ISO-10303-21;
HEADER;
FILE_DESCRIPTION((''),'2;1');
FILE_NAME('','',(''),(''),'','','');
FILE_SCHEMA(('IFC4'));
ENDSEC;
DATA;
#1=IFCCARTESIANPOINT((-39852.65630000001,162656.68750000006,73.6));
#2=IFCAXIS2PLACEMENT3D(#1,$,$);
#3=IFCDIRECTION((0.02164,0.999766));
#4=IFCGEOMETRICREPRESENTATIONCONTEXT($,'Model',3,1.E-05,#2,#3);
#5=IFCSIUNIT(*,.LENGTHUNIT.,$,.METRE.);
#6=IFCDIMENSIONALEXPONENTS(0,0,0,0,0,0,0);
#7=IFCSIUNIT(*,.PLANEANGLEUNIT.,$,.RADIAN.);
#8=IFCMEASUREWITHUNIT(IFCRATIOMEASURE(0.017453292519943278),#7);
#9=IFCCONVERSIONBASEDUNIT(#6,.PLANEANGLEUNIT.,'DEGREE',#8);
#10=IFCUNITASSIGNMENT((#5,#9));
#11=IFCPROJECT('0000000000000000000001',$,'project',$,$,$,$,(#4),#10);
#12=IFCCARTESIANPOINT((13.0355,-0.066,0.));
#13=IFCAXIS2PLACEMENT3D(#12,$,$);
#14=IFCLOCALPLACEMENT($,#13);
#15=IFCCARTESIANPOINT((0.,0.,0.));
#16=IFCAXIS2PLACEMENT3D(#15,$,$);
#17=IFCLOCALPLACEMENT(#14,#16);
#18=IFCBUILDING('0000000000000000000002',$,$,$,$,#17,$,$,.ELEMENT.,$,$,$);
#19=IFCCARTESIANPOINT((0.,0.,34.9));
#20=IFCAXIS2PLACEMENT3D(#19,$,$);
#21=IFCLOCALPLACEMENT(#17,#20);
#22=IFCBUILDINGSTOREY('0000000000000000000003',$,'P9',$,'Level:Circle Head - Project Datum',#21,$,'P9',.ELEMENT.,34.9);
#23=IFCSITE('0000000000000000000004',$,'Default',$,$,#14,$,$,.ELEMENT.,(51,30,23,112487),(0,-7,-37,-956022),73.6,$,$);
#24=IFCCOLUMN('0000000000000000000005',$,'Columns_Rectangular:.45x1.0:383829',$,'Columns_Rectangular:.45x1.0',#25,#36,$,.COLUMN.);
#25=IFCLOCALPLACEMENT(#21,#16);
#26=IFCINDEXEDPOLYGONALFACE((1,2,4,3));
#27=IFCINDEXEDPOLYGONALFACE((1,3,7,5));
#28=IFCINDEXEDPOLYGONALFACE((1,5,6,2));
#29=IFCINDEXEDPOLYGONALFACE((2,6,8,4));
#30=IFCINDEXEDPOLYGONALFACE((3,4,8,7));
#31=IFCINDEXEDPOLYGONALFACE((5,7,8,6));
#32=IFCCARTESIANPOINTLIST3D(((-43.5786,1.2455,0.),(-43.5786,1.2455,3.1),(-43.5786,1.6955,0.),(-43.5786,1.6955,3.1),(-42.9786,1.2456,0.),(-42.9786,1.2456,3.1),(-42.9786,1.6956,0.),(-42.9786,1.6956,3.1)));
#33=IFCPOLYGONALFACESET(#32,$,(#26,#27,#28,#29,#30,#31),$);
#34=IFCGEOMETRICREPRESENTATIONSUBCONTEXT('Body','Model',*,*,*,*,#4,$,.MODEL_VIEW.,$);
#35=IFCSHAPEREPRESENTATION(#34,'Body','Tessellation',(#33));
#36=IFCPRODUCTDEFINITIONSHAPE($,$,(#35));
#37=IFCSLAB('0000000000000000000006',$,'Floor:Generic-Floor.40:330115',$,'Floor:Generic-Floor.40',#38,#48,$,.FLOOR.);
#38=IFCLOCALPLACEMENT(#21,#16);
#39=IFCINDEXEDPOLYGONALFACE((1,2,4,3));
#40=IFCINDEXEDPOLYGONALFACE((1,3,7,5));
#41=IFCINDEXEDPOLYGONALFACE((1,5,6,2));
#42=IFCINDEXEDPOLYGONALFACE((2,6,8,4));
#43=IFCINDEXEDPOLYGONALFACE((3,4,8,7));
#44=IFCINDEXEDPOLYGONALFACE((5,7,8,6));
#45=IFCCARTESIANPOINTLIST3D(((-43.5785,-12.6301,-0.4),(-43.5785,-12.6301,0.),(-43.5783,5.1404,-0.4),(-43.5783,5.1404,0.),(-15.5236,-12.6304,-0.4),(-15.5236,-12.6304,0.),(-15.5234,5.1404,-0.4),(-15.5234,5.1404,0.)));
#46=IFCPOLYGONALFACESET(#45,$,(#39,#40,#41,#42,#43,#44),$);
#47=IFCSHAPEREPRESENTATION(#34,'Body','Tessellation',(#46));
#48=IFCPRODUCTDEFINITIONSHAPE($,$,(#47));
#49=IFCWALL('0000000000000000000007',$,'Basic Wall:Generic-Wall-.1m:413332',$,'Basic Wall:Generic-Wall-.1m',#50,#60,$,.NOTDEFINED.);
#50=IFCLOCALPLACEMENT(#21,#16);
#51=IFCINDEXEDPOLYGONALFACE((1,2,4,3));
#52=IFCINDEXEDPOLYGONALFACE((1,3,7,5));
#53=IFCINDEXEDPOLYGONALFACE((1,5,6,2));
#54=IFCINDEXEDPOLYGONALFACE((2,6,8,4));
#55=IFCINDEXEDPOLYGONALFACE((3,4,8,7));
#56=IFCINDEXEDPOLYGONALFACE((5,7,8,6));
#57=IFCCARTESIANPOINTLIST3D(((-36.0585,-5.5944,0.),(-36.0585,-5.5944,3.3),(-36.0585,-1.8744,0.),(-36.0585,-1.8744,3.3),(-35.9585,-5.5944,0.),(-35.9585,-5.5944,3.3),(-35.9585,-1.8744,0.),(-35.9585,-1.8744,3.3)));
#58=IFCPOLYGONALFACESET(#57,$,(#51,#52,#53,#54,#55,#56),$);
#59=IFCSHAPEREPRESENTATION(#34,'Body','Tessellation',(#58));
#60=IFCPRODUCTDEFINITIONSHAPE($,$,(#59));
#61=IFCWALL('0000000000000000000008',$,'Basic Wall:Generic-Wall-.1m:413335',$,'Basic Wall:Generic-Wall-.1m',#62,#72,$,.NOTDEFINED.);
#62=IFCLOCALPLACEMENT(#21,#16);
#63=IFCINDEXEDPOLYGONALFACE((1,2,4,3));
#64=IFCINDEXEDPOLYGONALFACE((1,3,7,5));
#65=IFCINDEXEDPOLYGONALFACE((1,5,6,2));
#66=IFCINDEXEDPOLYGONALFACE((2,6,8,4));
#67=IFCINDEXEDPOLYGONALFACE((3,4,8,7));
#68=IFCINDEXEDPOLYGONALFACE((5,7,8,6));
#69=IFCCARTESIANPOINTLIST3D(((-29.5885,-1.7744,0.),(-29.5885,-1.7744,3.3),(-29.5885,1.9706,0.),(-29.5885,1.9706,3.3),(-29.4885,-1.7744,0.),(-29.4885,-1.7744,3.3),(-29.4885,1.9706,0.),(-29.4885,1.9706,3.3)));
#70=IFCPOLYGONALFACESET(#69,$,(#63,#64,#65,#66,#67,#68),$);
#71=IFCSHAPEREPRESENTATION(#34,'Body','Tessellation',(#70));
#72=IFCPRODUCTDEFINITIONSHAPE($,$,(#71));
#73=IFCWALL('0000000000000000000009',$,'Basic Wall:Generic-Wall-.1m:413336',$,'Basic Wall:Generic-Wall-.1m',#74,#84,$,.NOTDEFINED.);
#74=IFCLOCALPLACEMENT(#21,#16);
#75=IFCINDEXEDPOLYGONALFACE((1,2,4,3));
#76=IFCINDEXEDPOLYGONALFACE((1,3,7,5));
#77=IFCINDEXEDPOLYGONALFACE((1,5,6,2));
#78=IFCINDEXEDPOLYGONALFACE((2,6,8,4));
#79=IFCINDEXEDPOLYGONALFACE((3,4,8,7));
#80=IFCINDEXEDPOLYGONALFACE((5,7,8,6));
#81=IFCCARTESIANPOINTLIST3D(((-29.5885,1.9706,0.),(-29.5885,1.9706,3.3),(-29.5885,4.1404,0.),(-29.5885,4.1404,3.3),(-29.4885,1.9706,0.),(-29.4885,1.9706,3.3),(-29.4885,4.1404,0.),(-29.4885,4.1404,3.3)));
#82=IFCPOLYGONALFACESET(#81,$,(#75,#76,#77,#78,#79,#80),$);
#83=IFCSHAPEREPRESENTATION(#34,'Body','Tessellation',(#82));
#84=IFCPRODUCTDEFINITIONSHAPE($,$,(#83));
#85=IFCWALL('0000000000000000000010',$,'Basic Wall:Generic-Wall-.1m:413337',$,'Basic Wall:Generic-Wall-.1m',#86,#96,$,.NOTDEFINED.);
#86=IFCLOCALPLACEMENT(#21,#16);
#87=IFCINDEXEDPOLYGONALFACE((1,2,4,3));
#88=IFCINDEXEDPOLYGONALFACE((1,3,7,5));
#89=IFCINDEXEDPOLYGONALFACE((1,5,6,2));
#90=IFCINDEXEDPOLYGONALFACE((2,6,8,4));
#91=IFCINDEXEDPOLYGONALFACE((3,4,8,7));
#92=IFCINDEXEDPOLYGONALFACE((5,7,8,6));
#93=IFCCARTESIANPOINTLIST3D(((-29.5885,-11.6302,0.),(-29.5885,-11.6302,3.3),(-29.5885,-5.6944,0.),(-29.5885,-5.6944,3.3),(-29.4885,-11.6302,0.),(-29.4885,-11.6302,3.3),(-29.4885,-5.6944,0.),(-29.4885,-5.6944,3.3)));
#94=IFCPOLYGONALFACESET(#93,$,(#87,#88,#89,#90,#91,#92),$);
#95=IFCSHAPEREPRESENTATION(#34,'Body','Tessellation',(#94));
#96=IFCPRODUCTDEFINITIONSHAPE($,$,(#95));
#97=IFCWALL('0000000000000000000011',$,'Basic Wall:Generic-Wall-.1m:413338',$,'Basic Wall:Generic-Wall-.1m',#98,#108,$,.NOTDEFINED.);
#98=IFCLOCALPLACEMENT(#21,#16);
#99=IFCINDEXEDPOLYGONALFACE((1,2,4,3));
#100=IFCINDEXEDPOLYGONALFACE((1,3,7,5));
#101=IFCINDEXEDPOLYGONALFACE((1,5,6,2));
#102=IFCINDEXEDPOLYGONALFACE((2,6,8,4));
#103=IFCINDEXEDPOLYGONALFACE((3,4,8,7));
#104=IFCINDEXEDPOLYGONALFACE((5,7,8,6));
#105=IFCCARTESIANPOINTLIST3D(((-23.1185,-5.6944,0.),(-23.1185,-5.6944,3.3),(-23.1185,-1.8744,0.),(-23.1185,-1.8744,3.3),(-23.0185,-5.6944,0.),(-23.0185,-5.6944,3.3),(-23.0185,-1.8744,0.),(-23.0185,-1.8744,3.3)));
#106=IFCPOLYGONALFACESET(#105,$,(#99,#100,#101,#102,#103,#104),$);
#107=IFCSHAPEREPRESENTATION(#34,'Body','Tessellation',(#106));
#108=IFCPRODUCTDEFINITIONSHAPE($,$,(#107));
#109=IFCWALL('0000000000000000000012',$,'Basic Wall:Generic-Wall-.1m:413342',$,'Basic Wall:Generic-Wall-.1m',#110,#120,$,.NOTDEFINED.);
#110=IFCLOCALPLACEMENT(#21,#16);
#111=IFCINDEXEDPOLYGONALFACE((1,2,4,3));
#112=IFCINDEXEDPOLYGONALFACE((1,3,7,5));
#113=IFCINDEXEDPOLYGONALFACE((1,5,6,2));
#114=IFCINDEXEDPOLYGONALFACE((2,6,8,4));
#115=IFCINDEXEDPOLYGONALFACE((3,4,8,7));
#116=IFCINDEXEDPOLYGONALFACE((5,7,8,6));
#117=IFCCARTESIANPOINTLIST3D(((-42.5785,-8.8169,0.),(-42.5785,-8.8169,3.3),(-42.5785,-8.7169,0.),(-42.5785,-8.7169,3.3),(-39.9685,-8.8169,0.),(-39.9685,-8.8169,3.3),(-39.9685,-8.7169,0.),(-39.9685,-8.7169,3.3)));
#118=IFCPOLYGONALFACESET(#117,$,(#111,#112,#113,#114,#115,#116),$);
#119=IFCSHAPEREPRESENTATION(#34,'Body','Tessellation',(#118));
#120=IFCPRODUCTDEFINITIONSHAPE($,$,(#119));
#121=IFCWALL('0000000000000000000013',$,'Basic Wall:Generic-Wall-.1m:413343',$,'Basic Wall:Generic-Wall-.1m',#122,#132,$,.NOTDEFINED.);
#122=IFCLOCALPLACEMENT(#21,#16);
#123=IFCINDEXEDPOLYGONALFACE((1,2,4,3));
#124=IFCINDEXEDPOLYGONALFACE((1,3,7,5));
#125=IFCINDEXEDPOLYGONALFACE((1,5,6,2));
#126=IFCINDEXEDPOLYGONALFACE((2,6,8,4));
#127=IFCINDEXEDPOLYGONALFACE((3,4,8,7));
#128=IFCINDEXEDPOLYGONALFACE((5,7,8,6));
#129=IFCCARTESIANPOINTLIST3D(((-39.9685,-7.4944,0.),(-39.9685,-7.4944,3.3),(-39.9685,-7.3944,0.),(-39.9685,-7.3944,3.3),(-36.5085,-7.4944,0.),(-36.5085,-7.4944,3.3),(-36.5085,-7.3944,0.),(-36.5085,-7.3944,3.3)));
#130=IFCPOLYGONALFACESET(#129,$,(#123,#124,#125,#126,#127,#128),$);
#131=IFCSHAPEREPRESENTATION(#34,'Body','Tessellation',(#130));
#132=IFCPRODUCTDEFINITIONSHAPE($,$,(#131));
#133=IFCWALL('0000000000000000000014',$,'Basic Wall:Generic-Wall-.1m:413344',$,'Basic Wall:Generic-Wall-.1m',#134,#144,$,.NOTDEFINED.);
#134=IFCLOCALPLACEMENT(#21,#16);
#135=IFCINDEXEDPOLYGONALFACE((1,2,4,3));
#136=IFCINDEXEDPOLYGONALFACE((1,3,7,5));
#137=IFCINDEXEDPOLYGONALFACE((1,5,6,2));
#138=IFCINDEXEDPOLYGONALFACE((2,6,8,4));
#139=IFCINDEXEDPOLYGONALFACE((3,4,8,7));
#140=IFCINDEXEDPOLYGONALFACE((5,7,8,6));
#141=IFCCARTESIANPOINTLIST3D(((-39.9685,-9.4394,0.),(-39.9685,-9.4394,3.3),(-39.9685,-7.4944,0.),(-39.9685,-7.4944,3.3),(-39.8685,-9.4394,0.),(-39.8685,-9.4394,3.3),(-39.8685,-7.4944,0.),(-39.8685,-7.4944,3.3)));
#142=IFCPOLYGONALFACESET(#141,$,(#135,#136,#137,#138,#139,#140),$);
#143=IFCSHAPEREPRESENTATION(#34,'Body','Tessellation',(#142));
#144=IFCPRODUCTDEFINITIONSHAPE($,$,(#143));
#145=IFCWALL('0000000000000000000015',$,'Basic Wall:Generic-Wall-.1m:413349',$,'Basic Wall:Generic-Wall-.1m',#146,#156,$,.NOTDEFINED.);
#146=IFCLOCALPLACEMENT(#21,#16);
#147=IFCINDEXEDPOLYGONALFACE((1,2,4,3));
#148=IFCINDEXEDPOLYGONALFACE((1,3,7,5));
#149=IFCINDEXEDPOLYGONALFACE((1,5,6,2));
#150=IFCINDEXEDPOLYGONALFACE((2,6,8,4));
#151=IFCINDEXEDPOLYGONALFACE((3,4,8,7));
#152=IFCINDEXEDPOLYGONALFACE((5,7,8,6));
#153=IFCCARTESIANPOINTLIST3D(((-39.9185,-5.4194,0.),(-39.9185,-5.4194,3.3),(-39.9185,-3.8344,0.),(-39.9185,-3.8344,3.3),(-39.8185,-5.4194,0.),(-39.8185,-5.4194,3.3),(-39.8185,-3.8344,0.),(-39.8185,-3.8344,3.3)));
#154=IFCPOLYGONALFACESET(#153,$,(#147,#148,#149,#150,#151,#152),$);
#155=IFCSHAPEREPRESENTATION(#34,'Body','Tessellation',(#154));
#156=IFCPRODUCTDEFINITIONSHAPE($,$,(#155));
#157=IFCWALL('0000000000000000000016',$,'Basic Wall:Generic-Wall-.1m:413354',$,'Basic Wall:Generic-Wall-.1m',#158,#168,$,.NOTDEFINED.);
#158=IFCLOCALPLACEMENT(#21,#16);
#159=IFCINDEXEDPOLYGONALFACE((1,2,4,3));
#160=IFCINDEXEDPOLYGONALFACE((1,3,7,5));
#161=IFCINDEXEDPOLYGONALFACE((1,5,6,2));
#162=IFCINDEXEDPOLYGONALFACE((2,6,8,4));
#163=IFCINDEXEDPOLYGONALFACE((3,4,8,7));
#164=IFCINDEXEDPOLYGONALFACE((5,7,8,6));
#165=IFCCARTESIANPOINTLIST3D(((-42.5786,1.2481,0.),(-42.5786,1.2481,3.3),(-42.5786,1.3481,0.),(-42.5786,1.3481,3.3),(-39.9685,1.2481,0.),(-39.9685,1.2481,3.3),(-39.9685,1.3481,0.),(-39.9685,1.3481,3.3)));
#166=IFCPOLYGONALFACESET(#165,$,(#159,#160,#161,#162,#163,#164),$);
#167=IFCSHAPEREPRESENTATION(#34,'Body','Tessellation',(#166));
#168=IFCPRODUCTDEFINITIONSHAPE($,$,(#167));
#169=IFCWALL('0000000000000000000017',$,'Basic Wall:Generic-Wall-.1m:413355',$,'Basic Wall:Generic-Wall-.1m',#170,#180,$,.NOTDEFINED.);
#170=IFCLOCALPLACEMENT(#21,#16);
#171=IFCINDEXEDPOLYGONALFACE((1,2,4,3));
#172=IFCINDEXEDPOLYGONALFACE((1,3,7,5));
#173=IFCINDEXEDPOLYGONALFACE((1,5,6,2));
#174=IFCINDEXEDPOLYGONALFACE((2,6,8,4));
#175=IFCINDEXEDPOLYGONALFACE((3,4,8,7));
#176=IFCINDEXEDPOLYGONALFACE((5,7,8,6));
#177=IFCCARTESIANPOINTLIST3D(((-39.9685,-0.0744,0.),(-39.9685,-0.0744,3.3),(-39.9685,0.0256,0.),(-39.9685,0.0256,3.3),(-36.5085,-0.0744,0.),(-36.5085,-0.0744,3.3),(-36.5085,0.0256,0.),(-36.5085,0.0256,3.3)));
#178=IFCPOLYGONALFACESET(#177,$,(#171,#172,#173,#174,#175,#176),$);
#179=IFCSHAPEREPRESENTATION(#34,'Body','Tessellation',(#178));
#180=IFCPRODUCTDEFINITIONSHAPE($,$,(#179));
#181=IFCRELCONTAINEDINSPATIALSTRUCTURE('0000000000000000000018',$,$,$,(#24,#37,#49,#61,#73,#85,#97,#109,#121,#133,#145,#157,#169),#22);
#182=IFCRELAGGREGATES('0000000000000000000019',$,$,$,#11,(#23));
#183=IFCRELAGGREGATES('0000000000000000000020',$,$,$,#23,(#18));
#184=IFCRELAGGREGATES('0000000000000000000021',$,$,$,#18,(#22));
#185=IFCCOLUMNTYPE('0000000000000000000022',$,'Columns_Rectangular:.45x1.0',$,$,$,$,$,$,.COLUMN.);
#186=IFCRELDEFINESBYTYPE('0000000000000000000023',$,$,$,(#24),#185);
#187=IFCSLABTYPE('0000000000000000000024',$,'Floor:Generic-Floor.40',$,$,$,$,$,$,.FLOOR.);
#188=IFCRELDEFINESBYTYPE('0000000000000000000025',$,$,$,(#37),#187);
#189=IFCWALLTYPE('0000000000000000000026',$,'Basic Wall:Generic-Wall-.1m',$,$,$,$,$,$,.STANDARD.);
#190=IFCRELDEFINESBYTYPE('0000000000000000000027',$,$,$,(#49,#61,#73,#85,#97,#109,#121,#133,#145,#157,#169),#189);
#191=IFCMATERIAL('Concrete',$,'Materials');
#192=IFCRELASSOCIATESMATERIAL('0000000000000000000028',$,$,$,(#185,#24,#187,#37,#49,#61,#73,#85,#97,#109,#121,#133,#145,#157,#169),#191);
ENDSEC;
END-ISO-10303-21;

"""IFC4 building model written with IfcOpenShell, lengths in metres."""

from ifc_helpers import new_model, entity, si_unit, converted_unit, direction, frame, origin, place, context, subcontext, project, spatial, indexed_curve, outline, extrude, source, transform, mapped, material, type_object, type_shapes, element, save


model = new_model("IFC4")

# Units and contexts
model_context = context("Model", 3, precision=1e-05, world=frame((-39852.65630000001, 162656.68750000006, 73.6)), true_north=direction((0.02164, 0.999766)))
body_context = subcontext(model_context, "Body", "Model", "MODEL_VIEW")
ifc_project = project(units=[si_unit("LENGTHUNIT", "METRE"), converted_unit("PLANEANGLEUNIT", "DEGREE", entity("IfcRatioMeasure", 0.017453292519943278), si_unit("PLANEANGLEUNIT", "RADIAN"), dimensions=[0, 0, 0, 0, 0, 0, 0])], contexts=[model_context])

# Site, building, storey
site_placement = place(None, frame((13.0355, -0.066, 0.0)))
site = spatial("IfcSite", under=ifc_project, at=site_placement, Name="Default", CompositionType="ELEMENT", RefLatitude=(51, 30, 23, 112487), RefLongitude=(0, -7, -37, -956022), RefElevation=73.6)
building_placement = place(site_placement, origin())
building = spatial("IfcBuilding", under=site, at=building_placement, CompositionType="ELEMENT")
storey_placement = place(building_placement, frame((0.0, 0.0, 34.9)))
storey = spatial("IfcBuildingStorey", under=building, at=storey_placement, Name="P9", ObjectType="Level:Circle Head - Project Datum", LongName="P9", CompositionType="ELEMENT", Elevation=34.9)

# Column
ifc_material = material(Name="Concrete", Category="Materials")
column_type = type_object("IfcColumnType", Name="Columns_Rectangular:.45x1.0", PredefinedType="COLUMN", material=ifc_material)
shared_shape = source(origin(), body_context, "Body", "SweptSolid", [
    extrude(outline(indexed_curve([(-0.3, -0.225), (0.3, -0.225), (0.3, 0.225), (-0.3, 0.225), (-0.3, -0.225)], self_intersect=False)), frame((-43.2786, 1.4706, 34.9), z_axis=(0.0, 0.0, 1.0), x_axis=(-1.0, -0.000005, 0.0)), (0.0, 0.0, 1.0), 3.1),
])
type_shapes(column_type, [shared_shape])
column_placement = place(storey_placement, frame((0.0, 0.0, -34.9)))
element("IfcColumn", 1, at=column_placement, inside=storey, type_object=column_type, material=ifc_material, Name="Columns_Rectangular:.45x1.0:383829", ObjectType="Columns_Rectangular:.45x1.0", PredefinedType="COLUMN", context=body_context, shape_type="MappedRepresentation", body=[
    mapped(shared_shape, transform((0.0, 0.0, 0.0), scale=1.0)),
])

# Slab
slab_type = type_object("IfcSlabType", Name="Floor:Generic-Floor.40", PredefinedType="FLOOR", material=ifc_material)
slab_placement = place(storey_placement, origin())
element("IfcSlab", 2, at=slab_placement, inside=storey, type_object=slab_type, material=ifc_material, Name="Floor:Generic-Floor.40:330115", ObjectType="Floor:Generic-Floor.40", PredefinedType="FLOOR", context=body_context, shape_type="SweptSolid", body=[
    extrude(outline(indexed_curve([(-14.0274, -8.8853), (14.0275, -8.8853), (14.0274, 8.8855), (-14.0275, 8.8852), (-14.0274, -8.8853)], self_intersect=False)), frame((-29.5509, -3.7449, 0.0), z_axis=(0.0, 0.0, -1.0), x_axis=(1.0, 0.0, 0.0)), (0.0, 0.0, 1.0), 0.4),
])

# Walls
wall_type_1 = type_object("IfcWallType", Name="Basic Wall:Generic-Wall-.1m", PredefinedType="STANDARD")
wall_1_placement = place(storey_placement, frame((-36.0085, -1.8744, 0.0), z_axis=(0.0, 0.0, 1.0), x_axis=(0.0, -1.0, 0.0)))
element("IfcWall", 3, at=wall_1_placement, inside=storey, type_object=wall_type_1, material=ifc_material, Name="Basic Wall:Generic-Wall-.1m:413332", ObjectType="Basic Wall:Generic-Wall-.1m", PredefinedType="NOTDEFINED", context=body_context, shape_type="SweptSolid", body=[
    extrude(outline(indexed_curve([(3.72, 0.05), (0.0, 0.05), (0.0, -0.05), (3.72, -0.05), (3.72, 0.05)], self_intersect=False)), origin(), (0.0, 0.0, 1.0), 3.3),
])
wall_2_placement = place(storey_placement, frame((-29.5385, 1.9706, 0.0), z_axis=(0.0, 0.0, 1.0), x_axis=(0.0, -1.0, 0.0)))
element("IfcWall", 4, at=wall_2_placement, inside=storey, type_object=wall_type_1, material=ifc_material, Name="Basic Wall:Generic-Wall-.1m:413335", ObjectType="Basic Wall:Generic-Wall-.1m", PredefinedType="NOTDEFINED", context=body_context, shape_type="SweptSolid", body=[
    extrude(outline(indexed_curve([(3.745, 0.05), (0.0, 0.05), (0.0, -0.05), (3.745, -0.05), (3.745, 0.05)], self_intersect=False)), origin(), (0.0, 0.0, 1.0), 3.3),
])
wall_3_placement = place(storey_placement, frame((-29.5385, 1.9706, 0.0), z_axis=(0.0, 0.0, 1.0), x_axis=(0.0, 1.0, 0.0)))
element("IfcWall", 5, at=wall_3_placement, inside=storey, type_object=wall_type_1, material=ifc_material, Name="Basic Wall:Generic-Wall-.1m:413336", ObjectType="Basic Wall:Generic-Wall-.1m", PredefinedType="NOTDEFINED", context=body_context, shape_type="SweptSolid", body=[
    extrude(outline(indexed_curve([(2.1699, 0.05), (0.0, 0.05), (0.0, -0.05), (2.1699, -0.05), (2.1699, 0.05)], self_intersect=False)), origin(), (0.0, 0.0, 1.0), 3.3),
])
wall_4_placement = place(storey_placement, frame((-29.5385, -5.6944, 0.0), z_axis=(0.0, 0.0, 1.0), x_axis=(0.0, -1.0, 0.0)))
element("IfcWall", 6, at=wall_4_placement, inside=storey, type_object=wall_type_1, material=ifc_material, Name="Basic Wall:Generic-Wall-.1m:413337", ObjectType="Basic Wall:Generic-Wall-.1m", PredefinedType="NOTDEFINED", context=body_context, shape_type="SweptSolid", body=[
    extrude(outline(indexed_curve([(5.9358, 0.05), (0.0, 0.05), (0.0, -0.05), (5.9358, -0.05), (5.9358, 0.05)], self_intersect=False)), origin(), (0.0, 0.0, 1.0), 3.3),
])
wall_5_placement = place(storey_placement, frame((-23.0685, -1.8744, 0.0), z_axis=(0.0, 0.0, 1.0), x_axis=(0.0, -1.0, 0.0)))
element("IfcWall", 7, at=wall_5_placement, inside=storey, type_object=wall_type_1, material=ifc_material, Name="Basic Wall:Generic-Wall-.1m:413338", ObjectType="Basic Wall:Generic-Wall-.1m", PredefinedType="NOTDEFINED", context=body_context, shape_type="SweptSolid", body=[
    extrude(outline(indexed_curve([(3.82, 0.05), (0.0, 0.05), (0.0, -0.05), (3.82, -0.05), (3.82, 0.05)], self_intersect=False)), origin(), (0.0, 0.0, 1.0), 3.3),
])
wall_6_placement = place(storey_placement, frame((-39.9685, -8.7669, 0.0), z_axis=(0.0, 0.0, 1.0), x_axis=(-1.0, 0.0, 0.0)))
element("IfcWall", 8, at=wall_6_placement, inside=storey, type_object=wall_type_1, material=ifc_material, Name="Basic Wall:Generic-Wall-.1m:413342", ObjectType="Basic Wall:Generic-Wall-.1m", PredefinedType="NOTDEFINED", context=body_context, shape_type="SweptSolid", body=[
    extrude(outline(indexed_curve([(2.61, 0.05), (0.0, 0.05), (0.0, -0.05), (2.61, -0.05), (2.61, 0.05)], self_intersect=False)), origin(), (0.0, 0.0, 1.0), 3.3),
])
wall_7_placement = place(storey_placement, frame((-36.5085, -7.4444, 0.0), z_axis=(0.0, 0.0, 1.0), x_axis=(-1.0, 0.0, 0.0)))
element("IfcWall", 9, at=wall_7_placement, inside=storey, type_object=wall_type_1, material=ifc_material, Name="Basic Wall:Generic-Wall-.1m:413343", ObjectType="Basic Wall:Generic-Wall-.1m", PredefinedType="NOTDEFINED", context=body_context, shape_type="SweptSolid", body=[
    extrude(outline(indexed_curve([(3.46, 0.05), (0.0, 0.05), (0.0, -0.05), (3.46, -0.05), (3.46, 0.05)], self_intersect=False)), origin(), (0.0, 0.0, 1.0), 3.3),
])
wall_8_placement = place(storey_placement, frame((-39.9185, -7.4944, 0.0), z_axis=(0.0, 0.0, 1.0), x_axis=(0.0, -1.0, 0.0)))
element("IfcWall", 10, at=wall_8_placement, inside=storey, type_object=wall_type_1, material=ifc_material, Name="Basic Wall:Generic-Wall-.1m:413344", ObjectType="Basic Wall:Generic-Wall-.1m", PredefinedType="NOTDEFINED", context=body_context, shape_type="SweptSolid", body=[
    extrude(outline(indexed_curve([(1.945, 0.05), (0.0, 0.05), (0.0, -0.05), (1.945, -0.05), (1.945, 0.05)], self_intersect=False)), origin(), (0.0, 0.0, 1.0), 3.3),
])
wall_9_placement = place(storey_placement, frame((-39.8685, -5.4194, 0.0), z_axis=(0.0, 0.0, 1.0), x_axis=(0.0, 1.0, 0.0)))
element("IfcWall", 11, at=wall_9_placement, inside=storey, type_object=wall_type_1, material=ifc_material, Name="Basic Wall:Generic-Wall-.1m:413349", ObjectType="Basic Wall:Generic-Wall-.1m", PredefinedType="NOTDEFINED", context=body_context, shape_type="SweptSolid", body=[
    extrude(outline(indexed_curve([(1.585, 0.05), (0.0, 0.05), (0.0, -0.05), (1.585, -0.05), (1.585, 0.05)], self_intersect=False)), origin(), (0.0, 0.0, 1.0), 3.3),
])
wall_10_placement = place(storey_placement, frame((-39.9685, 1.2981, 0.0), z_axis=(0.0, 0.0, 1.0), x_axis=(-1.0, 0.0, 0.0)))
element("IfcWall", 12, at=wall_10_placement, inside=storey, type_object=wall_type_1, material=ifc_material, Name="Basic Wall:Generic-Wall-.1m:413354", ObjectType="Basic Wall:Generic-Wall-.1m", PredefinedType="NOTDEFINED", context=body_context, shape_type="SweptSolid", body=[
    extrude(outline(indexed_curve([(2.6101, 0.05), (0.0, 0.05), (0.0, -0.05), (2.6101, -0.05), (2.6101, 0.05)], self_intersect=False)), origin(), (0.0, 0.0, 1.0), 3.3),
])
wall_11_placement = place(storey_placement, frame((-36.5085, -0.0244, 0.0), z_axis=(0.0, 0.0, 1.0), x_axis=(-1.0, 0.0, 0.0)))
element("IfcWall", 13, at=wall_11_placement, inside=storey, type_object=wall_type_1, material=ifc_material, Name="Basic Wall:Generic-Wall-.1m:413355", ObjectType="Basic Wall:Generic-Wall-.1m", PredefinedType="NOTDEFINED", context=body_context, shape_type="SweptSolid", body=[
    extrude(outline(indexed_curve([(3.46, 0.05), (0.0, 0.05), (0.0, -0.05), (3.46, -0.05), (3.46, 0.05)], self_intersect=False)), origin(), (0.0, 0.0, 1.0), 3.3),
])

save(model, "model.ifc")
